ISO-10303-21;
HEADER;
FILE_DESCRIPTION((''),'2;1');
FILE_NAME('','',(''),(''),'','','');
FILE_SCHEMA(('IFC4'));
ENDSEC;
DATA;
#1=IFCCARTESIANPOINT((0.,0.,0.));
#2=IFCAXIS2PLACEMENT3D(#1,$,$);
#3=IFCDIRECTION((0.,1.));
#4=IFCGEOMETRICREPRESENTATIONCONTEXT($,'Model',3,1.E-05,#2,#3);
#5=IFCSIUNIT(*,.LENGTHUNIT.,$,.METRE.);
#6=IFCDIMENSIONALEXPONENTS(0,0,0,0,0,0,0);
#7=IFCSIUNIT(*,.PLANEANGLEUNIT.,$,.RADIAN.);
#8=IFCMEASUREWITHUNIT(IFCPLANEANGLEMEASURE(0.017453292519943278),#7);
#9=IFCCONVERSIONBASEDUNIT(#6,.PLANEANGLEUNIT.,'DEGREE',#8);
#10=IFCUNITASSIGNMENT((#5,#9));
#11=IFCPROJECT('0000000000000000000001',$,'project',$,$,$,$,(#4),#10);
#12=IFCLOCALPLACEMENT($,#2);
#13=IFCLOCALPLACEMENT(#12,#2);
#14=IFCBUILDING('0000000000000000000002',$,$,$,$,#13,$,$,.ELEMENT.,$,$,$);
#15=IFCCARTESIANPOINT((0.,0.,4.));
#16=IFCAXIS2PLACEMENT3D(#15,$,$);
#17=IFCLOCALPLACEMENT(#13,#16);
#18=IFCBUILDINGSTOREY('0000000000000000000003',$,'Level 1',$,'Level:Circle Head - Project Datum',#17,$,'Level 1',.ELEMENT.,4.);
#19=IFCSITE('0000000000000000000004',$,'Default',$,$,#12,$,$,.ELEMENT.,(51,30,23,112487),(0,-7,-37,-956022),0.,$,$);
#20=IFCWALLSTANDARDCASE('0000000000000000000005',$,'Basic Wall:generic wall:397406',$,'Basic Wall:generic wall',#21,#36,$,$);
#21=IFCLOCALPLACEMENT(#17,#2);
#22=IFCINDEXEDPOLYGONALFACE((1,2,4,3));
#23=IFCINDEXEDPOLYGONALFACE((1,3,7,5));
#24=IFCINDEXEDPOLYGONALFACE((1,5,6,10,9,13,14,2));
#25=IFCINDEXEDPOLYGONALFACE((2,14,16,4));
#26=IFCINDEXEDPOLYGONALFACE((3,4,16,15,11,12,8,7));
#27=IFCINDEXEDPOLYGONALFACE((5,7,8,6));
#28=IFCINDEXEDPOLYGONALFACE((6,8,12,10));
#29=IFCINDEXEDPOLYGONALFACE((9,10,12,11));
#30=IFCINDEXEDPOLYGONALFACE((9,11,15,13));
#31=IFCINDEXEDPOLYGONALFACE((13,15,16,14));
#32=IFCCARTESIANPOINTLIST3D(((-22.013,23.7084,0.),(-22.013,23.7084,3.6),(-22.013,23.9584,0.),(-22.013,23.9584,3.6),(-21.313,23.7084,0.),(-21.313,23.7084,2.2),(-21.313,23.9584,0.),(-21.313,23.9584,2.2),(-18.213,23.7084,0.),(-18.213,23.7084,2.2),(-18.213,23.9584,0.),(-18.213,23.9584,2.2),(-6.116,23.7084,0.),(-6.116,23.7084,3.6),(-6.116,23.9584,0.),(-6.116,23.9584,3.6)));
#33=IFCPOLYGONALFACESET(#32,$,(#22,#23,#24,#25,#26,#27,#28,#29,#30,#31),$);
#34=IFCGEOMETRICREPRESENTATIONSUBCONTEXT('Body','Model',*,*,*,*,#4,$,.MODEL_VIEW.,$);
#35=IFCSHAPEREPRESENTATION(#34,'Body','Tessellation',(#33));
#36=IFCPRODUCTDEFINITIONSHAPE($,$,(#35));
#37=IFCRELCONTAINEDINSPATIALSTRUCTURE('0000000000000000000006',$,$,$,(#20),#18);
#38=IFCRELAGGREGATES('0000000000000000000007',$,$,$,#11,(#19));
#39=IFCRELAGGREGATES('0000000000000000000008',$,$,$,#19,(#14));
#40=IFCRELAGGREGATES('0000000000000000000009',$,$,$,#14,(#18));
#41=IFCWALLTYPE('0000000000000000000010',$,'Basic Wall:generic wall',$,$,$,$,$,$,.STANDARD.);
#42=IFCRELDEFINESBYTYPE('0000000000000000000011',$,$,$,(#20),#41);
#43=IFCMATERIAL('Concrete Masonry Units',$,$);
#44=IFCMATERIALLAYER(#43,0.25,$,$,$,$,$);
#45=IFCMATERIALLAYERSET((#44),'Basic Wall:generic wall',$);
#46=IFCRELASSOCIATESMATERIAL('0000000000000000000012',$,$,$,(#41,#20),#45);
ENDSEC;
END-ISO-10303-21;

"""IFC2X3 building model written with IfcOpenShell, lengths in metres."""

from ifc_helpers import new_model, entity, si_unit, converted_unit, direction, frame, frame_2d, origin, place, context, subcontext, project, spatial, rectangle, extrude, material, layer, layer_set, layer_usage, type_object, element, save


model = new_model("IFC2X3")

# Units and contexts
model_context = context("Model", 3, precision=1e-05, world=origin(), true_north=direction((0.0, 1.0)))
body_context = subcontext(model_context, "Body", "Model", "MODEL_VIEW")
ifc_project = project(units=[si_unit("LENGTHUNIT", "METRE"), converted_unit("PLANEANGLEUNIT", "DEGREE", entity("IfcPlaneAngleMeasure", 0.017453292519943278), si_unit("PLANEANGLEUNIT", "RADIAN"), dimensions=[0, 0, 0, 0, 0, 0, 0])], contexts=[model_context])

# Site, building, storey
site_placement = place(None, origin())
site = spatial("IfcSite", under=ifc_project, at=site_placement, Name="Default", CompositionType="ELEMENT", RefLatitude=(51, 30, 23, 112487), RefLongitude=(0, -7, -37, -956022), RefElevation=0.0)
building_placement = place(site_placement, origin())
building = spatial("IfcBuilding", under=site, at=building_placement, CompositionType="ELEMENT")
storey_placement = place(building_placement, frame((0.0, 0.0, 4.0)))
storey = spatial("IfcBuildingStorey", under=building, at=storey_placement, Name="Level 1", ObjectType="Level:Circle Head - Project Datum", LongName="Level 1", CompositionType="ELEMENT", Elevation=4.0)

# Shared definitions
ifc_material = material(Name="Concrete Masonry Units")
ifc_layer = layer(ifc_material, 0.25)
ifc_layer_set = layer_set([ifc_layer], Name="Basic Wall:generic wall")
wall_type = type_object("IfcWallType", Name="Basic Wall:generic wall", PredefinedType="STANDARD", material=ifc_layer_set)

# Wall, opening
ifc_layer_usage_1 = layer_usage(ifc_layer_set, "AXIS2", "NEGATIVE", 0.125)
wall_1_placement = place(storey_placement, frame((-6.116, 23.8334, 0.0), z_axis=(0.0, 0.0, 1.0), x_axis=(-1.0, 0.0, 0.0)))
wall_1 = element("IfcWallStandardCase", 1, at=wall_1_placement, inside=storey, type_object=wall_type, material=ifc_layer_usage_1, Name="Basic Wall:generic wall:397406", ObjectType="Basic Wall:generic wall", context=body_context, shape_type="SweptSolid", body=[
    extrude(rectangle(XDim=15.8969, YDim=0.25, at=frame_2d((7.9485, 0.0), x_axis=(-1.0, 0.0))), origin(), (0.0, 0.0, 1.0), 3.6),
])
opening_1_placement = place(wall_1_placement, frame((15.1969, 0.125, 0.0)))
element("IfcOpeningElement", 2, at=opening_1_placement, cuts=wall_1, ObjectType="Opening", context=body_context, shape_type="SweptSolid", body=[
    extrude(rectangle(XDim=2.2, YDim=3.1, at=frame_2d((1.1, 1.55), x_axis=(1.0, 0.0))), frame((0.0, 0.0, 0.0), z_axis=(0.0, -1.0, 0.0), x_axis=(0.0, 0.0, 1.0)), (0.0, 0.0, 1.0), 0.25),
])

save(model, "model.ifc")
